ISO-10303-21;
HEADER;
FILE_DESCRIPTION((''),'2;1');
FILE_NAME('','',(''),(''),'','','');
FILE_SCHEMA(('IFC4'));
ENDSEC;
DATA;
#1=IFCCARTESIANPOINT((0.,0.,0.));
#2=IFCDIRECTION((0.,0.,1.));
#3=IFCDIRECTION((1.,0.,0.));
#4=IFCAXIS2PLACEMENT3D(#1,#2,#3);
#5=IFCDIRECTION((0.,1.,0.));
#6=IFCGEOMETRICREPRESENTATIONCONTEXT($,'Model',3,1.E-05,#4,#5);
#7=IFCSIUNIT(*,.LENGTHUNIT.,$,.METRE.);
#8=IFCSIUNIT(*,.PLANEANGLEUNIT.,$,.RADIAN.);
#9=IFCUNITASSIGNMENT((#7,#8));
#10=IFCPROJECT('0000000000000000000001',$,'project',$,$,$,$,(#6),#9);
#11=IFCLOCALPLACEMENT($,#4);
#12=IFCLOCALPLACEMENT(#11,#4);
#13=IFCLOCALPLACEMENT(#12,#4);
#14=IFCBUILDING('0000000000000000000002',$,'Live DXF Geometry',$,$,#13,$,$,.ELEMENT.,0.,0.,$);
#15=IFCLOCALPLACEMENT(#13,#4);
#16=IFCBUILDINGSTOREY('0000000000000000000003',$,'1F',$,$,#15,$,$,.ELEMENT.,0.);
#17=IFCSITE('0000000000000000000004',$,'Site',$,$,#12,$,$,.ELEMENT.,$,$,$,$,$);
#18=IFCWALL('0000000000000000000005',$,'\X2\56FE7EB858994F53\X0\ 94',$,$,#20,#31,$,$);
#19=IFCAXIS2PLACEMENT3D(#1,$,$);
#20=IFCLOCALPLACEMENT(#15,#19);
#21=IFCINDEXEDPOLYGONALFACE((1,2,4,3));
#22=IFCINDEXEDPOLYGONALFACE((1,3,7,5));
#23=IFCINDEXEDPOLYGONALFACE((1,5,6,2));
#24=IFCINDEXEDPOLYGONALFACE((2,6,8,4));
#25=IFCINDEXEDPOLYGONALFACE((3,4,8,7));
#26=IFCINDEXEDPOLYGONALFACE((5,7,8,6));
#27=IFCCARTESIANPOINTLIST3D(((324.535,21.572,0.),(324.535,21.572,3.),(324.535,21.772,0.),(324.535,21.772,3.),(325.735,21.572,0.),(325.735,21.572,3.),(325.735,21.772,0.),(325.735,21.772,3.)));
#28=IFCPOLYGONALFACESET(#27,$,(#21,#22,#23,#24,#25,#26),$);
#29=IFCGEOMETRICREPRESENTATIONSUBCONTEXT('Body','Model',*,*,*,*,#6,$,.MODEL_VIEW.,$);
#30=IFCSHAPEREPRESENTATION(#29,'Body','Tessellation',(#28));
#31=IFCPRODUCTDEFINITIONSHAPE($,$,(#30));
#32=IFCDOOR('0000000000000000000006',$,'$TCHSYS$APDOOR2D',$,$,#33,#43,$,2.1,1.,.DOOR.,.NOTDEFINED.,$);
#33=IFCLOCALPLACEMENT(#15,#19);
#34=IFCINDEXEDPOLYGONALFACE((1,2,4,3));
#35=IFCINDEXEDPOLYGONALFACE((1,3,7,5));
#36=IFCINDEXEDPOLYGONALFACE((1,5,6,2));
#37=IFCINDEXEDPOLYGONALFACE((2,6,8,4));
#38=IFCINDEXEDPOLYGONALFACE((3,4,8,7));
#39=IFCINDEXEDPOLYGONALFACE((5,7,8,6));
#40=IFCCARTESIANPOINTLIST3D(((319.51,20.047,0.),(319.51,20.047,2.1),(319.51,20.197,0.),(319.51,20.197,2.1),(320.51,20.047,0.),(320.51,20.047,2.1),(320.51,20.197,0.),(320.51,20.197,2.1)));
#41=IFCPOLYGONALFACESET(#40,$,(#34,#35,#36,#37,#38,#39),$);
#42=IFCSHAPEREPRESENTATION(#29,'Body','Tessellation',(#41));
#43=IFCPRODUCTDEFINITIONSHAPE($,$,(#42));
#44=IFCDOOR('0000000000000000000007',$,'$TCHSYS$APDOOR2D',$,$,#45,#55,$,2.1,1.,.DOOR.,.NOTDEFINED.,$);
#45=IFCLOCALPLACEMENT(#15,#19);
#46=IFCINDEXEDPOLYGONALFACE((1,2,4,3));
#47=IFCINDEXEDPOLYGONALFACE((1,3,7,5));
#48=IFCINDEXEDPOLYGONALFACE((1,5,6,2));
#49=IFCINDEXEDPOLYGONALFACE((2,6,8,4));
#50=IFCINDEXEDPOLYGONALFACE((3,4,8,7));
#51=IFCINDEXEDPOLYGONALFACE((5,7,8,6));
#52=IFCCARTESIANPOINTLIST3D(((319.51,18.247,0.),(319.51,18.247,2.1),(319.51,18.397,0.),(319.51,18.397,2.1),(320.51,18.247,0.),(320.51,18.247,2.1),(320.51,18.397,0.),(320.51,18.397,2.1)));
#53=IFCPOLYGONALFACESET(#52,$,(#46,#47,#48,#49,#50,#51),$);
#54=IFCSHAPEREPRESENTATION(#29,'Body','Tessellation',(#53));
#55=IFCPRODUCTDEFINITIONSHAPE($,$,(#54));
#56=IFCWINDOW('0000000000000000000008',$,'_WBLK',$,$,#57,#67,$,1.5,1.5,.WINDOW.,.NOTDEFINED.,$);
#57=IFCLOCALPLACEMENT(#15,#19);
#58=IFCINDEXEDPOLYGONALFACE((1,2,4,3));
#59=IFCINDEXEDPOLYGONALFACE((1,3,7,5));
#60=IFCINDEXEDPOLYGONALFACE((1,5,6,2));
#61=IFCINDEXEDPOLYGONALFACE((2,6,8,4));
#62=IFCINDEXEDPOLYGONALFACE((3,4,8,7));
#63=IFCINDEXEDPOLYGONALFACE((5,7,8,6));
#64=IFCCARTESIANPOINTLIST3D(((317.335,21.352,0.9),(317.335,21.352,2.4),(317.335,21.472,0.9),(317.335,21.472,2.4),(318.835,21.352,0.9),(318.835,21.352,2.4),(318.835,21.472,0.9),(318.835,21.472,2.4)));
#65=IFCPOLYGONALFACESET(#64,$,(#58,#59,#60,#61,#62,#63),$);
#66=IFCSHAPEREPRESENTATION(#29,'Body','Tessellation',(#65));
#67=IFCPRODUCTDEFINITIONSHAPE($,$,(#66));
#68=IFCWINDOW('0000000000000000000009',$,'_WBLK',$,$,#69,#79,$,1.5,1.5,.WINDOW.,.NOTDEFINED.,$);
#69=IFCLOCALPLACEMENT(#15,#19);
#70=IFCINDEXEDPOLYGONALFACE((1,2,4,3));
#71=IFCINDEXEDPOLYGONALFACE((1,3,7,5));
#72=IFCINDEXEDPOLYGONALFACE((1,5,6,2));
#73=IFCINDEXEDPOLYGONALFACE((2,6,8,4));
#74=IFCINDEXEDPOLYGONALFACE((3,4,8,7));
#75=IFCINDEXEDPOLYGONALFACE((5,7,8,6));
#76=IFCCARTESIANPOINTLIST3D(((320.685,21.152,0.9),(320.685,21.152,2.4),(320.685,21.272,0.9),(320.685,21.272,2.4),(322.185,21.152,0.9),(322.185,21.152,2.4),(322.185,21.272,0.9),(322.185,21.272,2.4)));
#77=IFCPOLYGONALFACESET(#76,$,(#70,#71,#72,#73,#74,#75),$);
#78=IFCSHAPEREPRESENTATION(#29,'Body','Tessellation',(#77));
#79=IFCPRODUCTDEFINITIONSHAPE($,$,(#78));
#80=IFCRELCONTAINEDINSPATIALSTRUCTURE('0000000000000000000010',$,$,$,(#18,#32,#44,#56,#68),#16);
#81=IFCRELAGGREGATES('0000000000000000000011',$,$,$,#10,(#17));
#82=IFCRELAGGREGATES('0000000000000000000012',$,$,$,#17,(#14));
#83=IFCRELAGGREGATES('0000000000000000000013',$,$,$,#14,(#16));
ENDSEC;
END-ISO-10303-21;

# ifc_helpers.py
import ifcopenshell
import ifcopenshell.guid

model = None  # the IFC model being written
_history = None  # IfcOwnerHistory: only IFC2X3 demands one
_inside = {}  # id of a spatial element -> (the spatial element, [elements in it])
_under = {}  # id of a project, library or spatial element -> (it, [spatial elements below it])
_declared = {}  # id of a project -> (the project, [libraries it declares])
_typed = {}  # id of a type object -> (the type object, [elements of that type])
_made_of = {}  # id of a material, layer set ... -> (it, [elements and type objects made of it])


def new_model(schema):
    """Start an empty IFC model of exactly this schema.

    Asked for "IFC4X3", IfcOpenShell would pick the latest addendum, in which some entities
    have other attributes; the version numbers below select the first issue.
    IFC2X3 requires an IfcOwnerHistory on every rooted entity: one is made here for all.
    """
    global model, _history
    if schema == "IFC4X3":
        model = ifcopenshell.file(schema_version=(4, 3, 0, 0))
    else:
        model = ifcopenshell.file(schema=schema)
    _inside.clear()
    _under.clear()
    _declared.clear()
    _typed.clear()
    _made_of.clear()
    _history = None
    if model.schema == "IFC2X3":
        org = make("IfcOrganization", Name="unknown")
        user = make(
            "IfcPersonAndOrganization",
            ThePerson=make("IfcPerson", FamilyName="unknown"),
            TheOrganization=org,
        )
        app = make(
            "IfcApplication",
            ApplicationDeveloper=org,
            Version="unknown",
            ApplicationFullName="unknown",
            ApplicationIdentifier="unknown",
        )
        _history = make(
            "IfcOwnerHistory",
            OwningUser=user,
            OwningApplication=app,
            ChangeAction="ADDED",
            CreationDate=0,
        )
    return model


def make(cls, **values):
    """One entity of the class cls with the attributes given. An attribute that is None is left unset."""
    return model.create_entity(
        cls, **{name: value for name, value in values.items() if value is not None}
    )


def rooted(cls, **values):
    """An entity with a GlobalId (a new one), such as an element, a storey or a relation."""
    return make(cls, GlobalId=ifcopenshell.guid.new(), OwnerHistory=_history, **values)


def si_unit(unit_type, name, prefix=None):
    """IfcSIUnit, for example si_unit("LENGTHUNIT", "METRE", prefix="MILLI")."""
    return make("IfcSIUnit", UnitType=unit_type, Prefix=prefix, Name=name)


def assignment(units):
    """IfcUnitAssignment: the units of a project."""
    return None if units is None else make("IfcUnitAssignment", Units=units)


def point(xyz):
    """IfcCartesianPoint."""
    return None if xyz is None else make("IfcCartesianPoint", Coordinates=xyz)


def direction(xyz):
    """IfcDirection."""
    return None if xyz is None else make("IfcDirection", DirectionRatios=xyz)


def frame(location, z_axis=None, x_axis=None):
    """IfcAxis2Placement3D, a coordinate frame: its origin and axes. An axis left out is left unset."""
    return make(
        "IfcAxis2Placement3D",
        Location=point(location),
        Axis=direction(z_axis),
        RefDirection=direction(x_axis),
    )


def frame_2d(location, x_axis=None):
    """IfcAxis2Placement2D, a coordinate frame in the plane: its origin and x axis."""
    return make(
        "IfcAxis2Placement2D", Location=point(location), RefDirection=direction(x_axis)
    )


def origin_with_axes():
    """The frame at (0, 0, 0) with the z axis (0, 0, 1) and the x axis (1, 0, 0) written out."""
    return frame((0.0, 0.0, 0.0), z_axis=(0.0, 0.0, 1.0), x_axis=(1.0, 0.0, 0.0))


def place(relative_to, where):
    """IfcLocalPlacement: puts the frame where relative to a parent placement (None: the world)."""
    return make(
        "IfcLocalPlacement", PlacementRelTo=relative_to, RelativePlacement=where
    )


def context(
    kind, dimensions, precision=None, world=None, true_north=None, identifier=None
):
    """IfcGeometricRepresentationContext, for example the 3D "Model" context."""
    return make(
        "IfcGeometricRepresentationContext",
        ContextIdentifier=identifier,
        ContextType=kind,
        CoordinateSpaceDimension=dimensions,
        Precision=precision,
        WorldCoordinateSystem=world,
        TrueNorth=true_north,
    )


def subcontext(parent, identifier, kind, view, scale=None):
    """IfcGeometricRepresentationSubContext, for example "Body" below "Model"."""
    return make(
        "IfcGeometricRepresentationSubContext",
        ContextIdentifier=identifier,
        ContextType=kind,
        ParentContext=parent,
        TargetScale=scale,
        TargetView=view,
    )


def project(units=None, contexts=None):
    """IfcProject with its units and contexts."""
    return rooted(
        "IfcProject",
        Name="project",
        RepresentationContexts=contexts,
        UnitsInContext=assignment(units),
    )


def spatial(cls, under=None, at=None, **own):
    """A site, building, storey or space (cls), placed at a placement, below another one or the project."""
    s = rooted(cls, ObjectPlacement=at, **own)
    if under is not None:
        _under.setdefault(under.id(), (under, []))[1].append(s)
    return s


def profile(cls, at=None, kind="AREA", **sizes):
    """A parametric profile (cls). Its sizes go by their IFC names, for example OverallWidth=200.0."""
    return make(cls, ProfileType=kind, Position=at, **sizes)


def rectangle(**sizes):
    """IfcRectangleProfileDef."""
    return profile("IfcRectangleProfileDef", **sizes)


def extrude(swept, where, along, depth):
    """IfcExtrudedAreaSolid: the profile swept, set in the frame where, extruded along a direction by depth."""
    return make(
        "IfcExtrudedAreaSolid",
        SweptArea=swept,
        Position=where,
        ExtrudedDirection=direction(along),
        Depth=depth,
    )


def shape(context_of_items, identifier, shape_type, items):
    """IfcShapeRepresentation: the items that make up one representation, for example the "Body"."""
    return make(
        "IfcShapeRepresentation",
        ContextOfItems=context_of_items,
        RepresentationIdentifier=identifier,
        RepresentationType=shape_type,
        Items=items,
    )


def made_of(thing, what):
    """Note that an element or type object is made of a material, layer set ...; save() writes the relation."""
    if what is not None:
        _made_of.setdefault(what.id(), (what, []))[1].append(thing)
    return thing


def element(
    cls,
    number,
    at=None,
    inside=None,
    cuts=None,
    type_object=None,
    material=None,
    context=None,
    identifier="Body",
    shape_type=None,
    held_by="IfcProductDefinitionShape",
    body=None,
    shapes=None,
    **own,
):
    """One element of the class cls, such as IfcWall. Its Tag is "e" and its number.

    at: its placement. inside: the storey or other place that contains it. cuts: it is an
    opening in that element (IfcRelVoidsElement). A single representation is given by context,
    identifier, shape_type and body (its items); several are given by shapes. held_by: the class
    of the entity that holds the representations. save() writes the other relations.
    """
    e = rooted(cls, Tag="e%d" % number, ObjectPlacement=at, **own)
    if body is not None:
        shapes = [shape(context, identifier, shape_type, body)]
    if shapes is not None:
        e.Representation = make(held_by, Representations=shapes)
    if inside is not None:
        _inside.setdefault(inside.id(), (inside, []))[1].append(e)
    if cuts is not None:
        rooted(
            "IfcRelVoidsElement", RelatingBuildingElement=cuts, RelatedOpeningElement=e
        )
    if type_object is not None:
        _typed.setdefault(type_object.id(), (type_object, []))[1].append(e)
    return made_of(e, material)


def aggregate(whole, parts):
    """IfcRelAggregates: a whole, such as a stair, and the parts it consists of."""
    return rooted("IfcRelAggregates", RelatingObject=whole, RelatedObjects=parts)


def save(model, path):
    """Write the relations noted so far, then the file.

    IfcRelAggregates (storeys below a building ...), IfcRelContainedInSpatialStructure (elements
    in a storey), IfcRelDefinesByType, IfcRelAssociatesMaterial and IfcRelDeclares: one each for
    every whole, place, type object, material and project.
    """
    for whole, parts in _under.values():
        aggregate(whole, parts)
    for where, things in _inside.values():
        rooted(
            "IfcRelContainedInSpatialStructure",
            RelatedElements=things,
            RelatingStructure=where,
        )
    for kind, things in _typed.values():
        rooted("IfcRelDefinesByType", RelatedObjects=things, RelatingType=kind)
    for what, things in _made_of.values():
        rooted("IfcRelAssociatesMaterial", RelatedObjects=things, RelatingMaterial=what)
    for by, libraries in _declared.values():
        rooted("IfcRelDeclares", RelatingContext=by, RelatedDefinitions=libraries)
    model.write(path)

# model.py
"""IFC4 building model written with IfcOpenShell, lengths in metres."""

from ifc_helpers import new_model, si_unit, direction, frame, frame_2d, origin_with_axes, place, context, subcontext, project, spatial, rectangle, extrude, element, save


model = new_model("IFC4")

# Units and contexts
model_context = context("Model", 3, precision=1e-05, world=origin_with_axes(), true_north=direction((0.0, 1.0, 0.0)))
body_context = subcontext(model_context, "Body", "Model", "MODEL_VIEW")
ifc_project = project(units=[si_unit("LENGTHUNIT", "METRE"), si_unit("PLANEANGLEUNIT", "RADIAN")], contexts=[model_context])

# Site, building, storey
placement = place(None, origin_with_axes())
site_placement = place(placement, origin_with_axes())
site = spatial("IfcSite", under=ifc_project, at=site_placement, Name="Site", CompositionType="ELEMENT")
building_placement = place(site_placement, origin_with_axes())
building = spatial("IfcBuilding", under=site, at=building_placement, Name="Live DXF Geometry", CompositionType="ELEMENT", ElevationOfRefHeight=0.0, ElevationOfTerrain=0.0)
storey_placement = place(building_placement, origin_with_axes())
storey = spatial("IfcBuildingStorey", under=building, at=storey_placement, Name="1F", CompositionType="ELEMENT", Elevation=0.0)

# Wall
wall_1_placement = place(storey_placement, frame((325.135, 21.672, 0.0), z_axis=(0.0, 0.0, 1.0), x_axis=(1.0, 0.0, 0.0)))
element("IfcWall", 1, at=wall_1_placement, inside=storey, Name="图纸墙体 94", context=body_context, shape_type="SweptSolid", body=[
    extrude(rectangle(XDim=1.2, YDim=0.2, at=frame_2d((0.0, 0.0), x_axis=(1.0, 0.0, 0.0))), frame((0.0, 0.0, 0.0), z_axis=(0.0, 0.0, 1.0)), (0.0, 0.0, 1.0), 3.0),
])

# Doors
for number, where, z_axis, x_axis, name in (
    (2, (320.01, 20.122, 0.0), (0.0, 0.0, 1.0), (1.0, 0.0, 0.0), "$TCHSYS$APDOOR2D"),
    (3, (320.01, 18.322, 0.0), (0.0, 0.0, 1.0), (1.0, 0.0, 0.0), "$TCHSYS$APDOOR2D"),
):
    element("IfcDoor", number, at=place(storey_placement, frame(where, z_axis=z_axis, x_axis=x_axis)), inside=storey, Name=name, OperationType="NOTDEFINED", OverallHeight=2.1, OverallWidth=1.0, PredefinedType="DOOR", context=body_context, shape_type="SweptSolid", body=[
        extrude(rectangle(XDim=1.0, YDim=0.15, at=frame_2d((0.0, 0.0), x_axis=(1.0, 0.0, 0.0))), frame((0.0, 0.0, 0.0), z_axis=(0.0, 0.0, 1.0)), (0.0, 0.0, 1.0), 2.1),
    ])

# Windows
for number, where, z_axis, x_axis, name in (
    (4, (318.085, 21.412, 0.9), (0.0, 0.0, 1.0), (1.0, 0.0, 0.0), "_WBLK"),
    (5, (321.435, 21.212, 0.9), (0.0, 0.0, 1.0), (1.0, 0.0, 0.0), "_WBLK"),
):
    element("IfcWindow", number, at=place(storey_placement, frame(where, z_axis=z_axis, x_axis=x_axis)), inside=storey, Name=name, OverallHeight=1.5, OverallWidth=1.5, PartitioningType="NOTDEFINED", PredefinedType="WINDOW", context=body_context, shape_type="SweptSolid", body=[
        extrude(rectangle(XDim=1.5, YDim=0.12, at=frame_2d((0.0, 0.0), x_axis=(1.0, 0.0, 0.0))), frame((0.0, 0.0, 0.0), z_axis=(0.0, 0.0, 1.0)), (0.0, 0.0, 1.0), 1.5),
    ])

save(model, "model.ifc")
